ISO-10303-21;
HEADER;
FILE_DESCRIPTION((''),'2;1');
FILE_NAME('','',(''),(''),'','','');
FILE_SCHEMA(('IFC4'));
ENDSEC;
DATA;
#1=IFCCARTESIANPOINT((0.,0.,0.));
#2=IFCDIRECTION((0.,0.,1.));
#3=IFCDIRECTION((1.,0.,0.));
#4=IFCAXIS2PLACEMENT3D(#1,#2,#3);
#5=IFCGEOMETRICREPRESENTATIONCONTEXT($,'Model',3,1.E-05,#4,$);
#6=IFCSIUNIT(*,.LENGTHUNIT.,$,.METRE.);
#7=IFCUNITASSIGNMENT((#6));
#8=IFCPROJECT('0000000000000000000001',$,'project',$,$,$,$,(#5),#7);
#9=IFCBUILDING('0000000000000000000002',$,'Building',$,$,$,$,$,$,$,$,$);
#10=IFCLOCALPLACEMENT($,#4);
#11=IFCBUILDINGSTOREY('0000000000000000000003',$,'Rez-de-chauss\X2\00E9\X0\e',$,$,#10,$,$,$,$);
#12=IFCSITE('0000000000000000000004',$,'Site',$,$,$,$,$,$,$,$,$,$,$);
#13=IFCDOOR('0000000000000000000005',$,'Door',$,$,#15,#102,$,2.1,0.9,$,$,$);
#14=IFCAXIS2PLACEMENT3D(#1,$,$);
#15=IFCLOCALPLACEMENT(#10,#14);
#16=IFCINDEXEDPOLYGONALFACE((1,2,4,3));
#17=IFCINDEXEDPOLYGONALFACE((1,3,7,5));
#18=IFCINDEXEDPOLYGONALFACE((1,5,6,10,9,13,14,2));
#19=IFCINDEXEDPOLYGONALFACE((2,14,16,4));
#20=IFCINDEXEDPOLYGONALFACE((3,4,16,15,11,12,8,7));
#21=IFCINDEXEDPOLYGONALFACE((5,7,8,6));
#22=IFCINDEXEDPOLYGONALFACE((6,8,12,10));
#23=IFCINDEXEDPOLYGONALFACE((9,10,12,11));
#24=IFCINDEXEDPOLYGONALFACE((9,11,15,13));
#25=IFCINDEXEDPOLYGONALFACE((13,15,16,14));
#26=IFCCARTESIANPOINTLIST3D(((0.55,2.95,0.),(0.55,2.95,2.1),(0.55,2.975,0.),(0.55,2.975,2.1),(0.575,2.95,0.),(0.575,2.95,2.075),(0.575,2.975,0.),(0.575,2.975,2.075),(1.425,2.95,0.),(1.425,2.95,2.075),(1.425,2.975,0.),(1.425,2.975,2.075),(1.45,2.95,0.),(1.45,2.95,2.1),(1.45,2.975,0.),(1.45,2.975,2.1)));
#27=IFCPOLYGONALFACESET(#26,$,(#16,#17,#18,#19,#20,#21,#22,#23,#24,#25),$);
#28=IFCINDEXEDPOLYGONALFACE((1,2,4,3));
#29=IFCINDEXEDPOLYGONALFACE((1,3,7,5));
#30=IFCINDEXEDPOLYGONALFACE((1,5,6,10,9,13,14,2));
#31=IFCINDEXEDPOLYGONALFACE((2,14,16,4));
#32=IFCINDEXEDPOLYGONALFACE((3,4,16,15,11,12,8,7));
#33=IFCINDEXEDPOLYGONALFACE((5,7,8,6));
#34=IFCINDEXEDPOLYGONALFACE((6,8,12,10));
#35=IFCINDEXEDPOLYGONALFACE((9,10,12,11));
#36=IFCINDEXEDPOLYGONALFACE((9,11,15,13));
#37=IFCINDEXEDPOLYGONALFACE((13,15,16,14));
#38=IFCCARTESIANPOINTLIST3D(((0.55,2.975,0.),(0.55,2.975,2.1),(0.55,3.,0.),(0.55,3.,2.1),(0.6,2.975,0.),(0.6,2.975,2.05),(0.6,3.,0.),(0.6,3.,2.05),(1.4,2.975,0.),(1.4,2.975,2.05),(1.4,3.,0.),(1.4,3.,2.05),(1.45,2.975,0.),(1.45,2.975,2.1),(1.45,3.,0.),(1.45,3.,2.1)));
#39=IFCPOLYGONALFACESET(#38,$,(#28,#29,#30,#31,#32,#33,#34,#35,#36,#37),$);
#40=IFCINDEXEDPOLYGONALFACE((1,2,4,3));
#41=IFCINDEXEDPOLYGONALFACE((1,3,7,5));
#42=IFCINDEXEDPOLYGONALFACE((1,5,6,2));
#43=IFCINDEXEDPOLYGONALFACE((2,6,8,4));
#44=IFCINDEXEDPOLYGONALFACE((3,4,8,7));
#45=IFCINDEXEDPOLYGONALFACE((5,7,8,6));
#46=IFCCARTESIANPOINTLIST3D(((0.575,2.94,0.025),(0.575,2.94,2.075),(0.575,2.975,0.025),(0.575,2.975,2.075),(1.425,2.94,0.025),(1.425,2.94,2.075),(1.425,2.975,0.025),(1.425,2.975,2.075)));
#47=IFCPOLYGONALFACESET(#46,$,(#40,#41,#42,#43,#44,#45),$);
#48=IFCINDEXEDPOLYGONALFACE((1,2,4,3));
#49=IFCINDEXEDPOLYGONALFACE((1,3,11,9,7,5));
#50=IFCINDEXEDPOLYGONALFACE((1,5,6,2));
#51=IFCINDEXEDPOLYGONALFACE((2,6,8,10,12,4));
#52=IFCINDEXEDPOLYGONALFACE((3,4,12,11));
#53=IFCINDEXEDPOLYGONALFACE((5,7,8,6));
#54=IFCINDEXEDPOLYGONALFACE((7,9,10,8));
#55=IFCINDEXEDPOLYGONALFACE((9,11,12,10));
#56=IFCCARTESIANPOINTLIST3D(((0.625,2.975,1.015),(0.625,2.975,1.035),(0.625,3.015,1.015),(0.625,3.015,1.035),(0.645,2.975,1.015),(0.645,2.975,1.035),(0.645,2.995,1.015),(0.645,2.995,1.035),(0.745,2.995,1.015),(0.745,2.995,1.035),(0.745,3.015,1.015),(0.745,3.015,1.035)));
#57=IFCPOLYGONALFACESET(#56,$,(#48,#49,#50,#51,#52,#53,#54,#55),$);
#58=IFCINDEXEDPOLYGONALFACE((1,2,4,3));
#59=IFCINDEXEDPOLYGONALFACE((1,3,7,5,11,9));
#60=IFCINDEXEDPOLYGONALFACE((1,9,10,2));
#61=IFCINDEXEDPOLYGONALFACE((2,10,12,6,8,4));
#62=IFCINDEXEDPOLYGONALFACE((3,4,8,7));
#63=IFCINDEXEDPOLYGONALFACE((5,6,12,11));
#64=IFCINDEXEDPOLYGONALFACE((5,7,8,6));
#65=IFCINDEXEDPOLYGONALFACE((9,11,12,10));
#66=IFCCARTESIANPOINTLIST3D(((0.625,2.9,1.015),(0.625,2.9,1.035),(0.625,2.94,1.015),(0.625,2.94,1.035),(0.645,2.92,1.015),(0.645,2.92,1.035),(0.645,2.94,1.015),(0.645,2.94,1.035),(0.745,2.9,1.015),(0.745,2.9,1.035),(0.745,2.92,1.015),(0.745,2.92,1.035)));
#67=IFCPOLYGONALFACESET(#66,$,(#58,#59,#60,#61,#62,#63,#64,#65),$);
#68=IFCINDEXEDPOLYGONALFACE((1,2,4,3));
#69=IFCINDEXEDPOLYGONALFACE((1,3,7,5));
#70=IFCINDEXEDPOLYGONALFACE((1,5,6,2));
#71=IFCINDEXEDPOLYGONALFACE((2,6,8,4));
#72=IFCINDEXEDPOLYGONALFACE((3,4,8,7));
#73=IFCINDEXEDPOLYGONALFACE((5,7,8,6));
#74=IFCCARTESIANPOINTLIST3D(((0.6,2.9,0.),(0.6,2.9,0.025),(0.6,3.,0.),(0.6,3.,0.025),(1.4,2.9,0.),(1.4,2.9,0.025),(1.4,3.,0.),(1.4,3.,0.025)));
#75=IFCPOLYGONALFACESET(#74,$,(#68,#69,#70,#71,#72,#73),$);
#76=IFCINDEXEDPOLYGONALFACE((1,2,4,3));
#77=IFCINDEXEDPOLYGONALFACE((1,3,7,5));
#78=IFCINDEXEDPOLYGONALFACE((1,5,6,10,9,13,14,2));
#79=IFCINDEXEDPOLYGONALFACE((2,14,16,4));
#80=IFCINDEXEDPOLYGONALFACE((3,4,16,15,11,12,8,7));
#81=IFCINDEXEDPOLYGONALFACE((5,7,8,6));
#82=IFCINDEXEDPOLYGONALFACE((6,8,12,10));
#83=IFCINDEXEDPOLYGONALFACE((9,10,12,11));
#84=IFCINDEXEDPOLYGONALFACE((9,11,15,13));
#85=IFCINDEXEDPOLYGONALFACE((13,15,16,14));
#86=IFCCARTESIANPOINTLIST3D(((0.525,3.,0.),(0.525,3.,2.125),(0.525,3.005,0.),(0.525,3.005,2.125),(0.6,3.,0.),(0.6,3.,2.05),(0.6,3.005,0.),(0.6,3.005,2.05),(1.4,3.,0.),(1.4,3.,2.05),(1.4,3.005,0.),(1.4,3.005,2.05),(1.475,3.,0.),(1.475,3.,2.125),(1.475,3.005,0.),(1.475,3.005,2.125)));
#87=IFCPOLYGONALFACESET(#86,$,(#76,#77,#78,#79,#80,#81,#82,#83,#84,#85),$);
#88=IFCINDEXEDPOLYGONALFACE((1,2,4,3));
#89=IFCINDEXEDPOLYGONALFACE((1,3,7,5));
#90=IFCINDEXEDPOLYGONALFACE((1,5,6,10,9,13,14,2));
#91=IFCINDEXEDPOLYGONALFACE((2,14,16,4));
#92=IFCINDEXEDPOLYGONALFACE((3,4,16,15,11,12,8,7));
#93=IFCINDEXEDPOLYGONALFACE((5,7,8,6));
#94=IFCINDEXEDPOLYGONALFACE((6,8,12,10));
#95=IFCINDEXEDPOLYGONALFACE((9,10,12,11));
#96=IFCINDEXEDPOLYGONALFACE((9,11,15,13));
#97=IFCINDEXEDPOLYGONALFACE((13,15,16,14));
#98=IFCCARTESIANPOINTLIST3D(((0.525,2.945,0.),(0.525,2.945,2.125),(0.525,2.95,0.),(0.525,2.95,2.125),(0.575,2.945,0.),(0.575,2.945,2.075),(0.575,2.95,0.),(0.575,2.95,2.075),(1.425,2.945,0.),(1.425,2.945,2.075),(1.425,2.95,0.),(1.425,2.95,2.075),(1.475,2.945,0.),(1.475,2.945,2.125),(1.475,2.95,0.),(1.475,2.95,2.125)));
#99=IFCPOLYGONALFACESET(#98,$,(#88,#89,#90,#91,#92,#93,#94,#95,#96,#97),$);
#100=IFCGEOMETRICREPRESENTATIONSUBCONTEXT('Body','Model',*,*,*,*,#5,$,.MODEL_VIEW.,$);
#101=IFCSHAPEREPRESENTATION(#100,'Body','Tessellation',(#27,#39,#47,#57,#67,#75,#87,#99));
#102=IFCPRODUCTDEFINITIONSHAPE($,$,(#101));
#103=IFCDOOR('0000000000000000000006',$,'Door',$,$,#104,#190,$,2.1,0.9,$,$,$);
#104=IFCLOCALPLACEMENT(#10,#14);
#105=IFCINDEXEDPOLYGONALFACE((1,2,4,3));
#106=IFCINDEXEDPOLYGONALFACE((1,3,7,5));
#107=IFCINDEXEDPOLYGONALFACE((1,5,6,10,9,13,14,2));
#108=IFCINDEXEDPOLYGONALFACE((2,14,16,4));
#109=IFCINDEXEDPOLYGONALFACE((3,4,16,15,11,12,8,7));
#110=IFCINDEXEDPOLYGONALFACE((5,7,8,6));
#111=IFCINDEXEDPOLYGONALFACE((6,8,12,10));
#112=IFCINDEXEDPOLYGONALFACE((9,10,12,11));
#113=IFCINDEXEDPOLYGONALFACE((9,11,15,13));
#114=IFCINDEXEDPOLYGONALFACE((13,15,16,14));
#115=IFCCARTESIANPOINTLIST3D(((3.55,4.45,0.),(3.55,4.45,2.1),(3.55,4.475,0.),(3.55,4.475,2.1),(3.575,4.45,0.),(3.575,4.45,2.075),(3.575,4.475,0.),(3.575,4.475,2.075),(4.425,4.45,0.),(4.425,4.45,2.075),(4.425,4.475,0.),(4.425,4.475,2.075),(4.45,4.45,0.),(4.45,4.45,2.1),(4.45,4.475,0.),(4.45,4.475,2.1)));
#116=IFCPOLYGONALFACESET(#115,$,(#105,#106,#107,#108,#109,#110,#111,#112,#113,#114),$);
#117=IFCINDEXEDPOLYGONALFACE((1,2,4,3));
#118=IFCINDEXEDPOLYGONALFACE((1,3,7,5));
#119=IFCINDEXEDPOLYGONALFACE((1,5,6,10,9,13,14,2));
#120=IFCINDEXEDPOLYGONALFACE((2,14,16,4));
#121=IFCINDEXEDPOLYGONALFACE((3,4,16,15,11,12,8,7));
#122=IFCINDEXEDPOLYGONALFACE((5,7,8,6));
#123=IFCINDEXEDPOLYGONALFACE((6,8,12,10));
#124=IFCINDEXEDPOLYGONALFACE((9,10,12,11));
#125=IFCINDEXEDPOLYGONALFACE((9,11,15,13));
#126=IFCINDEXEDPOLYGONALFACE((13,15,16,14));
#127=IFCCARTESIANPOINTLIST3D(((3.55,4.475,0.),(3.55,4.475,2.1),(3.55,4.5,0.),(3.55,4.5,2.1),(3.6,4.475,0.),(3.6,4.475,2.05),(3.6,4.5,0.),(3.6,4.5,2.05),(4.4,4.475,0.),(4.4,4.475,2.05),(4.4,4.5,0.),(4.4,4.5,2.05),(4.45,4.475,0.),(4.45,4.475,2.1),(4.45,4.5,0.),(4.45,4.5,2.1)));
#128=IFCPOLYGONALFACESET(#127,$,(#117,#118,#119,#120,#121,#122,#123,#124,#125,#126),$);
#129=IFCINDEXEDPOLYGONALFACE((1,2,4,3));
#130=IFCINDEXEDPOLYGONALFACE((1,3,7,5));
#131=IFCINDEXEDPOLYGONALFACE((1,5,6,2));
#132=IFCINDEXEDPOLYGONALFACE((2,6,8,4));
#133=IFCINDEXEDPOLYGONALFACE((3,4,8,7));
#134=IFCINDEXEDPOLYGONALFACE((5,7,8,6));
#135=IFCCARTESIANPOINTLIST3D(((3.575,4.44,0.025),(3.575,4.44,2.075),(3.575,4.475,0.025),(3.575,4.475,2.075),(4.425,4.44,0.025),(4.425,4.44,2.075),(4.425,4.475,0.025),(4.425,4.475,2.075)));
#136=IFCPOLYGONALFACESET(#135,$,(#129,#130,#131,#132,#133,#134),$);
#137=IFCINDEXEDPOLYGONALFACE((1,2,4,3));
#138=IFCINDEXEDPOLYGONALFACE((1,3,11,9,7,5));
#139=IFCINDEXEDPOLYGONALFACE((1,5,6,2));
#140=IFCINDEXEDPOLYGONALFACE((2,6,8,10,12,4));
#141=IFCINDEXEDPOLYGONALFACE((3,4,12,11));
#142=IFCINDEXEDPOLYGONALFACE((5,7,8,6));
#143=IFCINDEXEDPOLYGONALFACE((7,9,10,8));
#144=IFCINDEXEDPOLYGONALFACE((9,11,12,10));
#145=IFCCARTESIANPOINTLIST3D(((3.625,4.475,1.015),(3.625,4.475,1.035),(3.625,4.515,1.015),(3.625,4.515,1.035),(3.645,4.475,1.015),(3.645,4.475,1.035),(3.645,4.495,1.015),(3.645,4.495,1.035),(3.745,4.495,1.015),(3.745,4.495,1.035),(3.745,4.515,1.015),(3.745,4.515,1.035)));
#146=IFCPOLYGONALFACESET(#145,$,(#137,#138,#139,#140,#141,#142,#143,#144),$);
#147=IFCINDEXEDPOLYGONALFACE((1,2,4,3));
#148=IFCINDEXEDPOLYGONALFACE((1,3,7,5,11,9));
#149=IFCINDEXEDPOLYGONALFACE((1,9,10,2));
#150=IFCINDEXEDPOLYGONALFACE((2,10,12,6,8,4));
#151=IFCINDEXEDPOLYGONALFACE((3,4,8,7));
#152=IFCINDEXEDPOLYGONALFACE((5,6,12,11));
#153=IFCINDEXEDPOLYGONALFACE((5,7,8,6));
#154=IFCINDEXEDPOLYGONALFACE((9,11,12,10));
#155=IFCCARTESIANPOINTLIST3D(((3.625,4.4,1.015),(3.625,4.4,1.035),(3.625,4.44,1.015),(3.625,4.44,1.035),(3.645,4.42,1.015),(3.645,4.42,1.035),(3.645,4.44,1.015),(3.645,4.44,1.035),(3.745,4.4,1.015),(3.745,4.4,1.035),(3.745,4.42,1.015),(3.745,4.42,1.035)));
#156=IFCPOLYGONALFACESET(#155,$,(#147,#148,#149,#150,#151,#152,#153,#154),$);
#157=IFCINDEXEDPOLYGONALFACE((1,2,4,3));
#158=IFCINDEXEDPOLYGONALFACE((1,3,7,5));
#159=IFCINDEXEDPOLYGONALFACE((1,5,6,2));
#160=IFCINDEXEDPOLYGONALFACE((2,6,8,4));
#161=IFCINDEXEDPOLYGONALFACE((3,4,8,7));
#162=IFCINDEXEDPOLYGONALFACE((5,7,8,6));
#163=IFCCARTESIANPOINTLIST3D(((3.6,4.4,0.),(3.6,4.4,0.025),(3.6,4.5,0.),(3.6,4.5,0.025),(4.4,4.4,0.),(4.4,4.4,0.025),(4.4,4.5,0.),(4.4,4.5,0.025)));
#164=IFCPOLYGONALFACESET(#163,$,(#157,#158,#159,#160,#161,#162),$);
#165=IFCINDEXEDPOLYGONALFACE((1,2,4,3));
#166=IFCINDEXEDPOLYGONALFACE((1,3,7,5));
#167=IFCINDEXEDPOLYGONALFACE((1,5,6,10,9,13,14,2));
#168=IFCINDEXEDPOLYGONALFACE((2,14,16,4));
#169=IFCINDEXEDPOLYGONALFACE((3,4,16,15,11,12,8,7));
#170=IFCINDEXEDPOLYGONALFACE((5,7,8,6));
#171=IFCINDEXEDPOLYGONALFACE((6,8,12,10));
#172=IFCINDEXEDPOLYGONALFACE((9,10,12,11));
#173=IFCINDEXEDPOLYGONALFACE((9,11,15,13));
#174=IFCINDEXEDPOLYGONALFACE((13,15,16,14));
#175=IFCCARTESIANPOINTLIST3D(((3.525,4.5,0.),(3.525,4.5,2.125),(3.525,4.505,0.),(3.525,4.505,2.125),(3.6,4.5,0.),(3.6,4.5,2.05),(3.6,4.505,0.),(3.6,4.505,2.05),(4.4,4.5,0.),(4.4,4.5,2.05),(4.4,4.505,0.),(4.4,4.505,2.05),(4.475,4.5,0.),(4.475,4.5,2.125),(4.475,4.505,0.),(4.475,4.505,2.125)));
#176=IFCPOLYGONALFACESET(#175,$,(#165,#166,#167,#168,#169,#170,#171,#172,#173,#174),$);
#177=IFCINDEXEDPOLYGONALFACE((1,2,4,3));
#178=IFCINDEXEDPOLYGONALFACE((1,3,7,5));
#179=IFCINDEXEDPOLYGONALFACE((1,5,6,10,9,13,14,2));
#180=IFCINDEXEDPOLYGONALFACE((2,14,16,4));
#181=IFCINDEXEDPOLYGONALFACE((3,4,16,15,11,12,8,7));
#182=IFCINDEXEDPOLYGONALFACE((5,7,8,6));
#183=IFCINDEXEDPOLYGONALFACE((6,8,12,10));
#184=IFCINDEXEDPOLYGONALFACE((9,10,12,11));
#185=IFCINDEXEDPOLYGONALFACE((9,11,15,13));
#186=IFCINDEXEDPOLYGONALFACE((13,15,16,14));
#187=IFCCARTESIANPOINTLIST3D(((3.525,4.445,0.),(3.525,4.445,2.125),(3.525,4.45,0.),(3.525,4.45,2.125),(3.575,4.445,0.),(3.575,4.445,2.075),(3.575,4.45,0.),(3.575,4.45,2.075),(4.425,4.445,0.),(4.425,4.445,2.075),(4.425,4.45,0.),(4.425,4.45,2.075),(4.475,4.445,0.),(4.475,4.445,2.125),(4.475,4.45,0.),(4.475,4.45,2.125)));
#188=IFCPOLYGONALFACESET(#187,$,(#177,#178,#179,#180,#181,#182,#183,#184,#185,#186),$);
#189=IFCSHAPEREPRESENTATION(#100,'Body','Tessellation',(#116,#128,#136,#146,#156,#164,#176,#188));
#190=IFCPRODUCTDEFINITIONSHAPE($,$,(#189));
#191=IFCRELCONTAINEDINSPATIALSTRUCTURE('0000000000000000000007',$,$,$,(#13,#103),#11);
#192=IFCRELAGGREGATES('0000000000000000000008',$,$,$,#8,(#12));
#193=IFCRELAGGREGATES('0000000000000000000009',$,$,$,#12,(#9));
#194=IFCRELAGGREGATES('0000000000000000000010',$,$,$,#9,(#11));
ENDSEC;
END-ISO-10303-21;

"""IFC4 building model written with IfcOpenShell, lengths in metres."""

from ifc_helpers import new_model, si_unit, frame, origin_with_axes, place, context, subcontext, project, spatial, line, indexed_curve, outline, extrude, element, save


model = new_model("IFC4")

# Units and contexts
model_context = context("Model", 3, precision=1e-05, world=origin_with_axes())
body_context = subcontext(model_context, "Body", "Model", "MODEL_VIEW")
ifc_project = project(units=[si_unit("LENGTHUNIT", "METRE")], contexts=[model_context])

# Site, building, storey
site = spatial("IfcSite", under=ifc_project, Name="Site")
building = spatial("IfcBuilding", under=site, Name="Building")
storey_placement = place(None, origin_with_axes())
storey = spatial("IfcBuildingStorey", under=building, at=storey_placement, Name="Rez-de-chaussée")

# Doors
door_1_placement = place(storey_placement, frame((1.45, 3.0, 0.0), z_axis=(0.0, 0.0, 1.0), x_axis=(-1.0, 0.0, 0.0)))
element("IfcDoor", 1, at=door_1_placement, inside=storey, Name="Door", OverallHeight=2.1, OverallWidth=0.9, context=body_context, shape_type="SweptSolid", body=[
    extrude(outline(indexed_curve([(0.0, 0.0), (0.0, 2.1), (0.9, 2.1), (0.9, 0.0), (0.875, 0.0), (0.875, 2.075), (0.025, 2.075), (0.025, 0.0)], segments=[line(1, 2, 3, 4, 5, 6, 7, 8, 1)])), frame((0.0, 0.025, 0.0), z_axis=(0.0, -1.0, 0.0), x_axis=(1.0, 0.0, 0.0)), (0.0, 0.0, -1.0), 0.025),
    extrude(outline(indexed_curve([(0.0, 0.0), (0.0, 2.1), (0.9, 2.1), (0.9, 0.0), (0.85, 0.0), (0.85, 2.05), (0.05, 2.05), (0.05, 0.0)], segments=[line(1, 2, 3, 4, 5, 6, 7, 8, 1)])), frame((0.0, 0.0, 0.0), z_axis=(0.0, -1.0, 0.0), x_axis=(1.0, 0.0, 0.0)), (0.0, 0.0, -1.0), 0.025),
    extrude(outline(indexed_curve([(0.0, 0.0), (0.85, 0.0), (0.85, 0.035), (0.0, 0.035)], segments=[line(1, 2, 3, 4, 1)])), frame((0.025, 0.025, 0.025), z_axis=(0.0, 0.0, 1.0), x_axis=(1.0, 0.0, 0.0)), (0.0, 0.0, 1.0), 2.05),
    extrude(outline(indexed_curve([(0.0, 0.0), (0.0, -0.04), (-0.12, -0.04), (-0.12, -0.02), (-0.02, -0.02), (-0.02, 0.0)], segments=[line(1, 2, 3, 4, 5, 6, 1)])), frame((0.825, 0.025, 1.015), z_axis=(0.0, 0.0, 1.0), x_axis=(1.0, 0.0, 0.0)), (0.0, 0.0, 1.0), 0.02),
    extrude(outline(indexed_curve([(0.0, 0.0), (0.0, 0.04), (-0.12, 0.04), (-0.12, 0.02), (-0.02, 0.02), (-0.02, 0.0)], segments=[line(1, 2, 3, 4, 5, 6, 1)])), frame((0.825, 0.06, 1.015), z_axis=(0.0, 0.0, 1.0), x_axis=(1.0, 0.0, 0.0)), (0.0, 0.0, 1.0), 0.02),
    extrude(outline(indexed_curve([(0.0, 0.0), (0.8, 0.0), (0.8, 0.1), (0.0, 0.1)], segments=[line(1, 2, 3, 4, 1)])), frame((0.05, 0.0, 0.0), z_axis=(0.0, 0.0, 1.0), x_axis=(1.0, 0.0, 0.0)), (0.0, 0.0, 1.0), 0.025),
    extrude(outline(indexed_curve([(0.0, 0.0), (0.0, 2.125), (0.95, 2.125), (0.95, 0.0), (0.875, 0.0), (0.875, 2.05), (0.075, 2.05), (0.075, 0.0)], segments=[line(1, 2, 3, 4, 5, 6, 7, 8, 1)])), frame((-0.025, -0.005, 0.0), z_axis=(0.0, -1.0, 0.0), x_axis=(1.0, 0.0, 0.0)), (0.0, 0.0, -1.0), 0.005),
    extrude(outline(indexed_curve([(0.0, 0.0), (0.0, 2.125), (0.95, 2.125), (0.95, 0.0), (0.9, 0.0), (0.9, 2.075), (0.05, 2.075), (0.05, 0.0)], segments=[line(1, 2, 3, 4, 5, 6, 7, 8, 1)])), frame((-0.025, 0.05, 0.0), z_axis=(0.0, -1.0, 0.0), x_axis=(1.0, 0.0, 0.0)), (0.0, 0.0, -1.0), 0.005),
])
door_2_placement = place(storey_placement, frame((4.45, 4.5, 0.0), z_axis=(0.0, 0.0, 1.0), x_axis=(-1.0, 0.0, 0.0)))
element("IfcDoor", 2, at=door_2_placement, inside=storey, Name="Door", OverallHeight=2.1, OverallWidth=0.9, context=body_context, shape_type="SweptSolid", body=[
    extrude(outline(indexed_curve([(0.0, 0.0), (0.0, 2.1), (0.9, 2.1), (0.9, 0.0), (0.875, 0.0), (0.875, 2.075), (0.025, 2.075), (0.025, 0.0)], segments=[line(1, 2, 3, 4, 5, 6, 7, 8, 1)])), frame((0.0, 0.025, 0.0), z_axis=(0.0, -1.0, 0.0), x_axis=(1.0, 0.0, 0.0)), (0.0, 0.0, -1.0), 0.025),
    extrude(outline(indexed_curve([(0.0, 0.0), (0.0, 2.1), (0.9, 2.1), (0.9, 0.0), (0.85, 0.0), (0.85, 2.05), (0.05, 2.05), (0.05, 0.0)], segments=[line(1, 2, 3, 4, 5, 6, 7, 8, 1)])), frame((0.0, 0.0, 0.0), z_axis=(0.0, -1.0, 0.0), x_axis=(1.0, 0.0, 0.0)), (0.0, 0.0, -1.0), 0.025),
    extrude(outline(indexed_curve([(0.0, 0.0), (0.85, 0.0), (0.85, 0.035), (0.0, 0.035)], segments=[line(1, 2, 3, 4, 1)])), frame((0.025, 0.025, 0.025), z_axis=(0.0, 0.0, 1.0), x_axis=(1.0, 0.0, 0.0)), (0.0, 0.0, 1.0), 2.05),
    extrude(outline(indexed_curve([(0.0, 0.0), (0.0, -0.04), (-0.12, -0.04), (-0.12, -0.02), (-0.02, -0.02), (-0.02, 0.0)], segments=[line(1, 2, 3, 4, 5, 6, 1)])), frame((0.825, 0.025, 1.015), z_axis=(0.0, 0.0, 1.0), x_axis=(1.0, 0.0, 0.0)), (0.0, 0.0, 1.0), 0.02),
    extrude(outline(indexed_curve([(0.0, 0.0), (0.0, 0.04), (-0.12, 0.04), (-0.12, 0.02), (-0.02, 0.02), (-0.02, 0.0)], segments=[line(1, 2, 3, 4, 5, 6, 1)])), frame((0.825, 0.06, 1.015), z_axis=(0.0, 0.0, 1.0), x_axis=(1.0, 0.0, 0.0)), (0.0, 0.0, 1.0), 0.02),
    extrude(outline(indexed_curve([(0.0, 0.0), (0.8, 0.0), (0.8, 0.1), (0.0, 0.1)], segments=[line(1, 2, 3, 4, 1)])), frame((0.05, 0.0, 0.0), z_axis=(0.0, 0.0, 1.0), x_axis=(1.0, 0.0, 0.0)), (0.0, 0.0, 1.0), 0.025),
    extrude(outline(indexed_curve([(0.0, 0.0), (0.0, 2.125), (0.95, 2.125), (0.95, 0.0), (0.875, 0.0), (0.875, 2.05), (0.075, 2.05), (0.075, 0.0)], segments=[line(1, 2, 3, 4, 5, 6, 7, 8, 1)])), frame((-0.025, -0.005, 0.0), z_axis=(0.0, -1.0, 0.0), x_axis=(1.0, 0.0, 0.0)), (0.0, 0.0, -1.0), 0.005),
    extrude(outline(indexed_curve([(0.0, 0.0), (0.0, 2.125), (0.95, 2.125), (0.95, 0.0), (0.9, 0.0), (0.9, 2.075), (0.05, 2.075), (0.05, 0.0)], segments=[line(1, 2, 3, 4, 5, 6, 7, 8, 1)])), frame((-0.025, 0.05, 0.0), z_axis=(0.0, -1.0, 0.0), x_axis=(1.0, 0.0, 0.0)), (0.0, 0.0, -1.0), 0.005),
])

save(model, "model.ifc")
